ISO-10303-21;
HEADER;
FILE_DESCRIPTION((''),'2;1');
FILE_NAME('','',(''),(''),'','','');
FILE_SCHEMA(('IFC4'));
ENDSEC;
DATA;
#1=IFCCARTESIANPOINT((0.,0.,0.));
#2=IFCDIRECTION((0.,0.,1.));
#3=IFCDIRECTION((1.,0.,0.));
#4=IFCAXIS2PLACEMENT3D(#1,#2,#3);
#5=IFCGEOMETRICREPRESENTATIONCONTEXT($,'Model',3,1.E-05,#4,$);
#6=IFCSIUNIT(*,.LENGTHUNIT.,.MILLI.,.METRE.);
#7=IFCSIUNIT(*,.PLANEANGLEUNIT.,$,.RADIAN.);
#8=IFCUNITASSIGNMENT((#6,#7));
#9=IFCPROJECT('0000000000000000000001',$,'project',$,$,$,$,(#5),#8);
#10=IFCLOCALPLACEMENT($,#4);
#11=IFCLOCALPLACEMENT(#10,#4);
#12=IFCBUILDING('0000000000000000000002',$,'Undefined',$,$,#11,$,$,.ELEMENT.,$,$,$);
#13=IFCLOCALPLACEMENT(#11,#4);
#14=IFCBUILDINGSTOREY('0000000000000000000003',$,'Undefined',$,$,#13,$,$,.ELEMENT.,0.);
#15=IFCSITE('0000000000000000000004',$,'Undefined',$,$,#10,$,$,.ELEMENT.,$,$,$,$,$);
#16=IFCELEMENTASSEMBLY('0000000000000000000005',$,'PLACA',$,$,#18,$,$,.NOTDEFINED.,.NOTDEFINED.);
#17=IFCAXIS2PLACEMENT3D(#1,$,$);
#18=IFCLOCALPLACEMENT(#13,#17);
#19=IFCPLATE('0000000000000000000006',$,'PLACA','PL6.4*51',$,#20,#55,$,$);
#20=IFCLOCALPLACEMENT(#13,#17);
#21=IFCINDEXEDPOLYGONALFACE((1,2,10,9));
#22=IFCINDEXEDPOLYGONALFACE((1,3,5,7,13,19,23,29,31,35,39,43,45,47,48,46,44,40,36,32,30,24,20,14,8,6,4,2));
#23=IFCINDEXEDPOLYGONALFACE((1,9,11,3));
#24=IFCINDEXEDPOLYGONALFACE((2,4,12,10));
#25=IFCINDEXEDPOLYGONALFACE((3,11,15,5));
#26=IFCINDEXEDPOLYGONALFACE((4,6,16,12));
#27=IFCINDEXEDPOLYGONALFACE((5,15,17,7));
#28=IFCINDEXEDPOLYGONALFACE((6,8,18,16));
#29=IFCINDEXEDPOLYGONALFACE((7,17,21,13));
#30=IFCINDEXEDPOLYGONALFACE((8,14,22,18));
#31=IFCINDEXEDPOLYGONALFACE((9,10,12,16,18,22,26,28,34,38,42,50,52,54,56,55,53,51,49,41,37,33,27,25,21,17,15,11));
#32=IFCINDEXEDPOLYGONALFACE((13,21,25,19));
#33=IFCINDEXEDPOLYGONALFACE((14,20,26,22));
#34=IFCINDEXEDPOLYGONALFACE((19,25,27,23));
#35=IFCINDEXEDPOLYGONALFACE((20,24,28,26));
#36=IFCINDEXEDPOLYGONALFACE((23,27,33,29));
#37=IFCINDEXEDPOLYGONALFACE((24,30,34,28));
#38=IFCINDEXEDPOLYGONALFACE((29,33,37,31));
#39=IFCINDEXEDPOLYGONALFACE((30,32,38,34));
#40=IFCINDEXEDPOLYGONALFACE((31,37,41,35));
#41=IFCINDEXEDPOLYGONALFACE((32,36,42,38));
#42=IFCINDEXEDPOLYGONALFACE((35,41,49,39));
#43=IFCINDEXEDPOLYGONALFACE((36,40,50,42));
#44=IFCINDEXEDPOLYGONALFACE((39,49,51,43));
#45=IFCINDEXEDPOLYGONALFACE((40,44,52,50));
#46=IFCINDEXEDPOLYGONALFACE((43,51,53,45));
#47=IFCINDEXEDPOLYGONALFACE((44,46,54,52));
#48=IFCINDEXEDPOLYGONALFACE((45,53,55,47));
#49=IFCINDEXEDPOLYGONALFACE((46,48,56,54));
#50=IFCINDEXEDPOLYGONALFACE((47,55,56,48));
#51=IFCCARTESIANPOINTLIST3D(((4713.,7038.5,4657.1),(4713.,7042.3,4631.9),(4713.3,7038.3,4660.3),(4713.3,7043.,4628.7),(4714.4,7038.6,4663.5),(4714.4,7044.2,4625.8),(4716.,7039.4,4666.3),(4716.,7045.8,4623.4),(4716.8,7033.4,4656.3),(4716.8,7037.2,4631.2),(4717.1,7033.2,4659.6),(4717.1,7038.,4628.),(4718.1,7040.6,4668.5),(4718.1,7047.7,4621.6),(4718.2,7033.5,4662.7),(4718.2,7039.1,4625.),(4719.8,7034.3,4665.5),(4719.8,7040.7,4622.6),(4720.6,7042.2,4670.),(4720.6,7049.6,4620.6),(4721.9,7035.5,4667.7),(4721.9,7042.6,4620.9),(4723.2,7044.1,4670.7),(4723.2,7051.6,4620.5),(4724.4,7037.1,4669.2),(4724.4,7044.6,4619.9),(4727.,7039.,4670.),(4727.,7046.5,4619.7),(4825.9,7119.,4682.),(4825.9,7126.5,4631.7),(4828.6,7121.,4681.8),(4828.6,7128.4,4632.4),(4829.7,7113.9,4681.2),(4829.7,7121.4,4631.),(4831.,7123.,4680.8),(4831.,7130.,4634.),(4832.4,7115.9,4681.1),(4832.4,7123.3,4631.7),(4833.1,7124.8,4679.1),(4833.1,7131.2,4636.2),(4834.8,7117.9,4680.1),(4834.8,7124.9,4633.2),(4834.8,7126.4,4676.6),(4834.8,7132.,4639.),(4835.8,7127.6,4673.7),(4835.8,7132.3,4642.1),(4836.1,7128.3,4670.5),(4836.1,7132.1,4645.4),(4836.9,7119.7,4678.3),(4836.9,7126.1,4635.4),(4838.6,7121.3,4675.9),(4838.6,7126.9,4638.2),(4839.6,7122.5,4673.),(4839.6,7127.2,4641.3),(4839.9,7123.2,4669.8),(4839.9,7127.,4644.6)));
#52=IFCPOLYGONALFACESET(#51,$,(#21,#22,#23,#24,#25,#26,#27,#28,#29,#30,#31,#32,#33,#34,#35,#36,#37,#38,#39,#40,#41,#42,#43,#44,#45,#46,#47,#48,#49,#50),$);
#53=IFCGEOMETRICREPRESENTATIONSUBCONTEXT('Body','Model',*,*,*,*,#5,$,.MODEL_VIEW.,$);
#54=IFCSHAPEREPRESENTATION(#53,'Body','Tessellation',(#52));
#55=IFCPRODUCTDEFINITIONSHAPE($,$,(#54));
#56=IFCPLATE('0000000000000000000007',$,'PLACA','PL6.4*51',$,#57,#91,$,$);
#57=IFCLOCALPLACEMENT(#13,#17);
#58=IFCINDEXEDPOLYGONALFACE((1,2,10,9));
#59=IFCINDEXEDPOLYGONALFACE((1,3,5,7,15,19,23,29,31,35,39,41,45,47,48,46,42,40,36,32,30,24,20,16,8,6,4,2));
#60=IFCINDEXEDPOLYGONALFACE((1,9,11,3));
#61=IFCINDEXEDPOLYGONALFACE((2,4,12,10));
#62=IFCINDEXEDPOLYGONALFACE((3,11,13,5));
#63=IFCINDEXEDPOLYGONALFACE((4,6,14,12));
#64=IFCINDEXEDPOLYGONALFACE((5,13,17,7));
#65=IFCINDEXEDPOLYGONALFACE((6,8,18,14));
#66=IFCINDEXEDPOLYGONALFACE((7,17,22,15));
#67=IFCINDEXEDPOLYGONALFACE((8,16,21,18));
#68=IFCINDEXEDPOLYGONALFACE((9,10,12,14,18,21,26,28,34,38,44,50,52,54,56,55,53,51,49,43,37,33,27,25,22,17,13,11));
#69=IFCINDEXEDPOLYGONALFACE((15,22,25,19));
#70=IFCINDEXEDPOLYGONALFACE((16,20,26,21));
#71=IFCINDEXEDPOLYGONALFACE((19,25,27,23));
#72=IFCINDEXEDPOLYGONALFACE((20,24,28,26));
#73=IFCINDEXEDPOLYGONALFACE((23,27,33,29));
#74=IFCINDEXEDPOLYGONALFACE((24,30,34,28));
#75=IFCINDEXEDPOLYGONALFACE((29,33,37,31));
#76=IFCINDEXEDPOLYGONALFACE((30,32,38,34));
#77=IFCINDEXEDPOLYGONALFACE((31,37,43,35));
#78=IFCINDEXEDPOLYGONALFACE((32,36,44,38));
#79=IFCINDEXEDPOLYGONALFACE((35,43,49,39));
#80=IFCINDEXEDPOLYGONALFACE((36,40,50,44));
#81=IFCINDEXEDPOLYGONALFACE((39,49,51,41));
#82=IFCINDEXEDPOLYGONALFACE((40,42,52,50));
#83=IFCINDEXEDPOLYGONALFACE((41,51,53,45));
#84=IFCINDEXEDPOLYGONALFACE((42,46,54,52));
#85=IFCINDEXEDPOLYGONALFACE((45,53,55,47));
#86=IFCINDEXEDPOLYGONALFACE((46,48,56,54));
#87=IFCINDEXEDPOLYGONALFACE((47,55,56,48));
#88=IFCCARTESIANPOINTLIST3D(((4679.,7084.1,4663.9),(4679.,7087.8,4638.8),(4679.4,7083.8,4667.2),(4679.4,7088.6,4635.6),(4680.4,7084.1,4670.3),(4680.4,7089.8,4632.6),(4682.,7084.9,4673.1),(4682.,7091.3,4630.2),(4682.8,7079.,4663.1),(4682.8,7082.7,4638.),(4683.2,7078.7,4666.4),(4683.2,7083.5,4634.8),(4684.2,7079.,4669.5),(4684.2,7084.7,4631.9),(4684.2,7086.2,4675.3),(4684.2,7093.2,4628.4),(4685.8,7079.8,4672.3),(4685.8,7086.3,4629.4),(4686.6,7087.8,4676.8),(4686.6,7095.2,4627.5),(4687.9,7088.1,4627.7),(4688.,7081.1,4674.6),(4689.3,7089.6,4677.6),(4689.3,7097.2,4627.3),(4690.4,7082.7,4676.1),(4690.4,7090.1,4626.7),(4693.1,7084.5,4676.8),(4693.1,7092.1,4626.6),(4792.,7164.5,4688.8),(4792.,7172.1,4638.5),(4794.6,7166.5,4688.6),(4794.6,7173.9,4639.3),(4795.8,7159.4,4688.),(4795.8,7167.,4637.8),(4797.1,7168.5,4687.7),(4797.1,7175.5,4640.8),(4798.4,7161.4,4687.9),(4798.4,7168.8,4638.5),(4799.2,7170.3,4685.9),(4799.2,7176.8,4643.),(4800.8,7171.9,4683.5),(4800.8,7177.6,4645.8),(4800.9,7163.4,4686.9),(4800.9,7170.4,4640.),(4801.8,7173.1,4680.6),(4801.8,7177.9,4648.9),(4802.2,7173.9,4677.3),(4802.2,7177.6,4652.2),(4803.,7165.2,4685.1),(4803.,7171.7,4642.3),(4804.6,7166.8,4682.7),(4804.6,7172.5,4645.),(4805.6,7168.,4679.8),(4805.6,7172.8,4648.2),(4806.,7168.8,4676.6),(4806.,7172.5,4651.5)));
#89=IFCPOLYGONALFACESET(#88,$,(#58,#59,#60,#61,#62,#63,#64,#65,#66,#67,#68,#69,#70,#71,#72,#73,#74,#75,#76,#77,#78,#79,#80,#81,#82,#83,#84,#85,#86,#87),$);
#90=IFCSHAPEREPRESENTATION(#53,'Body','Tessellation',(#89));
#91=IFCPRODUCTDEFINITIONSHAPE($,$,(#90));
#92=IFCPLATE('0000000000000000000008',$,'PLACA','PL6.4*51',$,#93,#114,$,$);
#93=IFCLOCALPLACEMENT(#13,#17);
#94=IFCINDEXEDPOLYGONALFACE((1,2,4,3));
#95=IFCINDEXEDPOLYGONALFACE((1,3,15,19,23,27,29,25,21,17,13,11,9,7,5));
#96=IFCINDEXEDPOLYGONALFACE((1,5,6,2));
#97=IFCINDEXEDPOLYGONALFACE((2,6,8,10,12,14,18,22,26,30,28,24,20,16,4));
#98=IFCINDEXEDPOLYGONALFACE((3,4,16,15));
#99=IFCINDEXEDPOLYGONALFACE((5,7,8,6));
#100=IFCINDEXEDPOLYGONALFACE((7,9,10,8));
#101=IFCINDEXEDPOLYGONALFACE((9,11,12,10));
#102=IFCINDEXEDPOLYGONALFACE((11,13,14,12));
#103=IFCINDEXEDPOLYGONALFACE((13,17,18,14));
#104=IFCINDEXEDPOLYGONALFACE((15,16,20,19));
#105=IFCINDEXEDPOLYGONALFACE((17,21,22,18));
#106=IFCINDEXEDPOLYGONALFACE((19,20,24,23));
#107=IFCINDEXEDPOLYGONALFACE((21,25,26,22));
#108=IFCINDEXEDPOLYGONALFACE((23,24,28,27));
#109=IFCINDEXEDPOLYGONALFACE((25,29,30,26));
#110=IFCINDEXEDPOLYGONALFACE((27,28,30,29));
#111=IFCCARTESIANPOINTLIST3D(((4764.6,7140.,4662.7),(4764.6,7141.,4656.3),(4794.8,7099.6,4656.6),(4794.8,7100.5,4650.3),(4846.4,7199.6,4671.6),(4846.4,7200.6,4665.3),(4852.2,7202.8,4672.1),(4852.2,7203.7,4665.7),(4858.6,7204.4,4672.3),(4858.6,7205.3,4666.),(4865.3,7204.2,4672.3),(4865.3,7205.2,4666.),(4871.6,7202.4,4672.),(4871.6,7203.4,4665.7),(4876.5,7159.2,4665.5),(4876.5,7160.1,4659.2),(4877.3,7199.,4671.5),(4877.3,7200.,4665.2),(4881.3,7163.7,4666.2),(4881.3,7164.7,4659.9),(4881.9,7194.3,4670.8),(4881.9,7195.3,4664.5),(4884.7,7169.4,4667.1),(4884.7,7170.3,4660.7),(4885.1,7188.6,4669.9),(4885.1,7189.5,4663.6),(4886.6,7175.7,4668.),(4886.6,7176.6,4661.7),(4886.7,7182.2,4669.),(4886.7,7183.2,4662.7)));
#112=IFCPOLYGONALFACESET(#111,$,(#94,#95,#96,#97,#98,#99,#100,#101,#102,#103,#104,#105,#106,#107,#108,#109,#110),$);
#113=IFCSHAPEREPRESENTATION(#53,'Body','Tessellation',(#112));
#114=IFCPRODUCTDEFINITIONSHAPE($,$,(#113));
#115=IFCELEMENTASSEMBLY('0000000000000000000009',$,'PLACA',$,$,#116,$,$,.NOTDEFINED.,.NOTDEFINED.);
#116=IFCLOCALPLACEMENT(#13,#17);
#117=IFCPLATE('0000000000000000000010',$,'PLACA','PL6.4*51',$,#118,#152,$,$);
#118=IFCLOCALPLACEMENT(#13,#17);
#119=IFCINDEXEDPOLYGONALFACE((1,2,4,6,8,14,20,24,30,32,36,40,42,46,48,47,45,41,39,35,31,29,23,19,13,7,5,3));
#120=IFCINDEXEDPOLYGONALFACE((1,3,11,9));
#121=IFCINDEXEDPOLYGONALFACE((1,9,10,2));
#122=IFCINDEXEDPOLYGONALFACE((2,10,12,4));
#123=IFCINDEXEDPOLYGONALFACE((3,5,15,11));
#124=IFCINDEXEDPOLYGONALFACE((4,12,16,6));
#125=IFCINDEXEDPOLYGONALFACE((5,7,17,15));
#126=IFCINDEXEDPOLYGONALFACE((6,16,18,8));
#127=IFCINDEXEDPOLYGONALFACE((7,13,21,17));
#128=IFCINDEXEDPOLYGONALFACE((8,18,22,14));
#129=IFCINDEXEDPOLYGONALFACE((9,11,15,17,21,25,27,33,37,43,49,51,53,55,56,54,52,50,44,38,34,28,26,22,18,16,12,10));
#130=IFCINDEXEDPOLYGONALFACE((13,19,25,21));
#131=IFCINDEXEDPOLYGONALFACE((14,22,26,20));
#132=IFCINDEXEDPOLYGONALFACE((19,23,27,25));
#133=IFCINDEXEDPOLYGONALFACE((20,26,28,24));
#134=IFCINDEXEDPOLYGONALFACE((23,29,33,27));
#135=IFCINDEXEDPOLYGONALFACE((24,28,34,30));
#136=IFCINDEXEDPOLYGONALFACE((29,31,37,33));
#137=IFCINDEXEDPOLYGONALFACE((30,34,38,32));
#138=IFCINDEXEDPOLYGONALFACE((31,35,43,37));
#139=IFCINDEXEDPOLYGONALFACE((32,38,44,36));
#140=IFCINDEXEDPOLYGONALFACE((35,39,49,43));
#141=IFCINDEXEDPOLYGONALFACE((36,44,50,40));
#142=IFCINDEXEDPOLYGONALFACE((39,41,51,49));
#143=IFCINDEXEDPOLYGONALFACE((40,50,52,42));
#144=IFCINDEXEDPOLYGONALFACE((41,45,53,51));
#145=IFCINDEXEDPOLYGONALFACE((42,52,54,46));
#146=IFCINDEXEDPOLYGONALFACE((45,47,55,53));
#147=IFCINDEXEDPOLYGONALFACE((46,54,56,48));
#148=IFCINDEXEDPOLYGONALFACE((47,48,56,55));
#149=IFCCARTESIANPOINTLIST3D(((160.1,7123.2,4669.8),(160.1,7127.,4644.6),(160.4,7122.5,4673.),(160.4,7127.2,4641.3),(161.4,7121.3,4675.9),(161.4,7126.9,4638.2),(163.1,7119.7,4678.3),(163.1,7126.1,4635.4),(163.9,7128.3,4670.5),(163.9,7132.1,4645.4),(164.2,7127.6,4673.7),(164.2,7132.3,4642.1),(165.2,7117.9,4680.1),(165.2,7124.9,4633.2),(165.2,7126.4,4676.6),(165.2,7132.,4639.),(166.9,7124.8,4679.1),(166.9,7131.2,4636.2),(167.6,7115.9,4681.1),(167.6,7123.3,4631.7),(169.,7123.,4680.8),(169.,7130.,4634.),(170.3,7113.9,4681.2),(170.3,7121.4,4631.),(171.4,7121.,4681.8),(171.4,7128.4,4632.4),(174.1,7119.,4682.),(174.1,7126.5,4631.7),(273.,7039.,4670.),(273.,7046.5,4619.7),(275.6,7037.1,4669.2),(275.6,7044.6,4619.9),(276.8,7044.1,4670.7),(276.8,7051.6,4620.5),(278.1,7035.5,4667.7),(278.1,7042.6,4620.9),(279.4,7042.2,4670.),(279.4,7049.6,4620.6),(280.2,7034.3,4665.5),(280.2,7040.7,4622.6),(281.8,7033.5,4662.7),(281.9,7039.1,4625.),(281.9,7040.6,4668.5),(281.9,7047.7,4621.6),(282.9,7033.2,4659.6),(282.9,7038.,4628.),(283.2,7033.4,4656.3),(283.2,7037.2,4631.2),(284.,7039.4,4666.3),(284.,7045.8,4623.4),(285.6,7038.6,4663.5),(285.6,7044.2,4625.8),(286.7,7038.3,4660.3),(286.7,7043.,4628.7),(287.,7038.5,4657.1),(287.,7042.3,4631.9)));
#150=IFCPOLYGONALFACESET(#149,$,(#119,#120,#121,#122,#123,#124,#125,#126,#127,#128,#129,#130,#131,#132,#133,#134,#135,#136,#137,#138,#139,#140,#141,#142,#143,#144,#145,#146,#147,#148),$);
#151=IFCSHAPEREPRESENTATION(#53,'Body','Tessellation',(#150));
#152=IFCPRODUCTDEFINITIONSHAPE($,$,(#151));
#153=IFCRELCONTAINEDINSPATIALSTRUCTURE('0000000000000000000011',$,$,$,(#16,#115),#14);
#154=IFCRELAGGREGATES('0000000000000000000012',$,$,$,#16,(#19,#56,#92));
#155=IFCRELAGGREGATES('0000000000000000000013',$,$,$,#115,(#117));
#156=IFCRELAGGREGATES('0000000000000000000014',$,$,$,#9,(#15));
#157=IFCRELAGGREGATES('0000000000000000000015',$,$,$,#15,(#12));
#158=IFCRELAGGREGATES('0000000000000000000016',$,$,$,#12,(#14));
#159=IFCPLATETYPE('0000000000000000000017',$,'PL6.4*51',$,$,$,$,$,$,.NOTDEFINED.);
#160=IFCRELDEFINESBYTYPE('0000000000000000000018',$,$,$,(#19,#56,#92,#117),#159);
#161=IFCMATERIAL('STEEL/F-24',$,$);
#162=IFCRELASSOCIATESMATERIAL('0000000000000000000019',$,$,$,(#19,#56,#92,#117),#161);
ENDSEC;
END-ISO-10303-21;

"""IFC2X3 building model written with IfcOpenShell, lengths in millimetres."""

from ifc_helpers import new_model, si_unit, frame, frame_2d, origin_with_axes, place, context, subcontext, project, spatial, polyline, circle_curve, parameter, trimmed, segment, composite_curve, outline, extrude, material, type_object, element, aggregate, save


model = new_model("IFC2X3")

# Units and contexts
model_context = context("Model", 3, precision=1e-05, world=origin_with_axes())
body_context = subcontext(model_context, "Body", "Model", "MODEL_VIEW")
ifc_project = project(units=[si_unit("LENGTHUNIT", "METRE", prefix="MILLI"), si_unit("PLANEANGLEUNIT", "RADIAN")], contexts=[model_context])

# Site, building, storey
site_placement = place(None, origin_with_axes())
site = spatial("IfcSite", under=ifc_project, at=site_placement, Name="Undefined", CompositionType="ELEMENT")
building_placement = place(site_placement, origin_with_axes())
building = spatial("IfcBuilding", under=site, at=building_placement, Name="Undefined", CompositionType="ELEMENT")
storey_placement = place(building_placement, origin_with_axes())
storey = spatial("IfcBuildingStorey", under=building, at=storey_placement, Name="Undefined", CompositionType="ELEMENT", Elevation=0.0)

# Shared definitions
ifc_material_1 = material(Name="STEEL/F-24")

# Element assemblies, plates
assembly_1_placement = place(storey_placement, origin_with_axes())
assembly_1 = element("IfcElementAssembly", 1, at=assembly_1_placement, inside=storey, Name="PLACA", AssemblyPlace="NOTDEFINED", PredefinedType="NOTDEFINED")
plate_type_1 = type_object("IfcPlateType", Name="PL6.4*51", PredefinedType="NOTDEFINED")
plate_1_placement = place(assembly_1_placement, frame((4838.0, 7131.4, 4632.5), z_axis=(0.593392, -0.796008, -0.119399), x_axis=(0.00003, -0.148316, 0.98894)))
plate_1 = element("IfcPlate", 2, at=plate_1_placement, type_object=plate_type_1, material=ifc_material_1, Name="PLACA", Description="PL6.4*51", context=body_context, shape_type="SweptSolid", body=[
    extrude(outline(composite_curve([segment(trimmed(circle_curve(frame_2d((12.7, 12.7), x_axis=(-1.0, 0.0)), 12.7), [parameter(0.0)], [parameter(1.570796)], True, "PARAMETER"), True, "CONTINUOUS"), segment(polyline([(12.7, 0.0), (38.1, 0.0)]), True, "CONTINUOUS"), segment(trimmed(circle_curve(frame_2d((38.1, 12.7), x_axis=(0.0, -1.0)), 12.7), [parameter(0.0)], [parameter(1.570796)], True, "PARAMETER"), True, "CONTINUOUS"), segment(polyline([(50.8, 12.7), (50.8, 140.3)]), True, "CONTINUOUS"), segment(trimmed(circle_curve(frame_2d((38.1, 140.3), x_axis=(1.0, 0.0)), 12.7), [parameter(0.0)], [parameter(1.570796)], True, "PARAMETER"), True, "CONTINUOUS"), segment(polyline([(38.1, 153.0), (12.7, 153.0)]), True, "CONTINUOUS"), segment(trimmed(circle_curve(frame_2d((12.7, 140.3), x_axis=(0.0, 1.0)), 12.7), [parameter(0.0)], [parameter(1.570796)], True, "PARAMETER"), True, "CONTINUOUS"), segment(polyline([(0.0, 140.3), (0.0, 12.7)]), True, "CONTINUOUS")], self_intersect=True)), frame((0.0, 0.0, -3.2), z_axis=(0.0, 0.0, 1.0), x_axis=(1.0, 0.0, 0.0)), (0.0, 0.0, 1.0), 6.4),
])
plate_2_placement = place(assembly_1_placement, frame((4804.1, 7177.0, 4639.3), z_axis=(0.593392, -0.796008, -0.119399), x_axis=(0.00003, -0.148316, 0.98894)))
plate_2 = element("IfcPlate", 3, at=plate_2_placement, type_object=plate_type_1, material=ifc_material_1, Name="PLACA", Description="PL6.4*51", context=body_context, shape_type="SweptSolid", body=[
    extrude(outline(composite_curve([segment(trimmed(circle_curve(frame_2d((12.7, 12.7), x_axis=(-1.0, 0.0)), 12.7), [parameter(0.0)], [parameter(1.570796)], True, "PARAMETER"), True, "CONTINUOUS"), segment(polyline([(12.7, 0.0), (38.1, 0.0)]), True, "CONTINUOUS"), segment(trimmed(circle_curve(frame_2d((38.1, 12.7), x_axis=(0.0, -1.0)), 12.7), [parameter(0.0)], [parameter(1.570796)], True, "PARAMETER"), True, "CONTINUOUS"), segment(polyline([(50.8, 12.7), (50.8, 140.3)]), True, "CONTINUOUS"), segment(trimmed(circle_curve(frame_2d((38.1, 140.3), x_axis=(1.0, 0.0)), 12.7), [parameter(0.0)], [parameter(1.570796)], True, "PARAMETER"), True, "CONTINUOUS"), segment(polyline([(38.1, 153.0), (12.7, 153.0)]), True, "CONTINUOUS"), segment(trimmed(circle_curve(frame_2d((12.7, 140.3), x_axis=(0.0, 1.0)), 12.7), [parameter(0.0)], [parameter(1.570796)], True, "PARAMETER"), True, "CONTINUOUS"), segment(polyline([(0.0, 140.3), (0.0, 12.7)]), True, "CONTINUOUS")], self_intersect=True)), frame((0.0, 0.0, -3.2), z_axis=(0.0, 0.0, 1.0), x_axis=(1.0, 0.0, 0.0)), (0.0, 0.0, 1.0), 6.4),
])
plate_3_placement = place(assembly_1_placement, frame((4897.0, 7174.6, 4664.6), z_axis=(0.00003, -0.148316, 0.98894), x_axis=(-0.593392, 0.796009, 0.119399)))
plate_3 = element("IfcPlate", 4, at=plate_3_placement, type_object=plate_type_1, material=ifc_material_1, Name="PLACA", Description="PL6.4*51", context=body_context, shape_type="SweptSolid", body=[
    extrude(outline(composite_curve([segment(trimmed(circle_curve(frame_2d((25.4, 25.4), x_axis=(-1.0, 0.0)), 25.4), [parameter(0.0)], [parameter(1.570796)], True, "PARAMETER"), True, "CONTINUOUS"), segment(polyline([(25.4, 0.0), (25.4, 0.0)]), True, "CONTINUOUS"), segment(trimmed(circle_curve(frame_2d((25.4, 25.4), x_axis=(0.0, -1.0)), 25.4), [parameter(0.0)], [parameter(1.570797)], True, "PARAMETER"), True, "CONTINUOUS"), segment(polyline([(50.8, 25.4), (50.8, 127.0), (0.0, 127.0), (0.0, 25.4)]), True, "CONTINUOUS")], self_intersect=True)), frame((0.0, 0.0, -3.2), z_axis=(0.0, 0.0, 1.0), x_axis=(1.0, 0.0, 0.0)), (0.0, 0.0, 1.0), 6.4),
])
assembly_2_placement = place(storey_placement, origin_with_axes())
assembly_2 = element("IfcElementAssembly", 5, at=assembly_2_placement, inside=storey, Name="PLACA", AssemblyPlace="NOTDEFINED", PredefinedType="NOTDEFINED")
plate_4_placement = place(assembly_2_placement, frame((162.0, 7131.4, 4632.5), z_axis=(0.593392, 0.796009, 0.119399), x_axis=(-0.00003, -0.148316, 0.98894)))
plate_4 = element("IfcPlate", 6, at=plate_4_placement, type_object=plate_type_1, material=ifc_material_1, Name="PLACA", Description="PL6.4*51", context=body_context, shape_type="SweptSolid", body=[
    extrude(outline(composite_curve([segment(trimmed(circle_curve(frame_2d((12.7, 12.7), x_axis=(-1.0, 0.0)), 12.7), [parameter(0.0)], [parameter(1.570796)], True, "PARAMETER"), True, "CONTINUOUS"), segment(polyline([(12.7, 0.0), (38.1, 0.0)]), True, "CONTINUOUS"), segment(trimmed(circle_curve(frame_2d((38.1, 12.7), x_axis=(0.0, -1.0)), 12.7), [parameter(0.0)], [parameter(1.570796)], True, "PARAMETER"), True, "CONTINUOUS"), segment(polyline([(50.8, 12.7), (50.8, 140.3)]), True, "CONTINUOUS"), segment(trimmed(circle_curve(frame_2d((38.1, 140.3), x_axis=(1.0, 0.0)), 12.7), [parameter(0.0)], [parameter(1.570796)], True, "PARAMETER"), True, "CONTINUOUS"), segment(polyline([(38.1, 153.0), (12.7, 153.0)]), True, "CONTINUOUS"), segment(trimmed(circle_curve(frame_2d((12.7, 140.3), x_axis=(0.0, 1.0)), 12.7), [parameter(0.0)], [parameter(1.570796)], True, "PARAMETER"), True, "CONTINUOUS"), segment(polyline([(0.0, 140.3), (0.0, 12.7)]), True, "CONTINUOUS")], self_intersect=True)), frame((0.0, 0.0, -3.2), z_axis=(0.0, 0.0, 1.0), x_axis=(1.0, 0.0, 0.0)), (0.0, 0.0, 1.0), 6.4),
])

aggregate(assembly_1, [plate_1, plate_2, plate_3])
aggregate(assembly_2, [plate_4])

save(model, "model.ifc")
